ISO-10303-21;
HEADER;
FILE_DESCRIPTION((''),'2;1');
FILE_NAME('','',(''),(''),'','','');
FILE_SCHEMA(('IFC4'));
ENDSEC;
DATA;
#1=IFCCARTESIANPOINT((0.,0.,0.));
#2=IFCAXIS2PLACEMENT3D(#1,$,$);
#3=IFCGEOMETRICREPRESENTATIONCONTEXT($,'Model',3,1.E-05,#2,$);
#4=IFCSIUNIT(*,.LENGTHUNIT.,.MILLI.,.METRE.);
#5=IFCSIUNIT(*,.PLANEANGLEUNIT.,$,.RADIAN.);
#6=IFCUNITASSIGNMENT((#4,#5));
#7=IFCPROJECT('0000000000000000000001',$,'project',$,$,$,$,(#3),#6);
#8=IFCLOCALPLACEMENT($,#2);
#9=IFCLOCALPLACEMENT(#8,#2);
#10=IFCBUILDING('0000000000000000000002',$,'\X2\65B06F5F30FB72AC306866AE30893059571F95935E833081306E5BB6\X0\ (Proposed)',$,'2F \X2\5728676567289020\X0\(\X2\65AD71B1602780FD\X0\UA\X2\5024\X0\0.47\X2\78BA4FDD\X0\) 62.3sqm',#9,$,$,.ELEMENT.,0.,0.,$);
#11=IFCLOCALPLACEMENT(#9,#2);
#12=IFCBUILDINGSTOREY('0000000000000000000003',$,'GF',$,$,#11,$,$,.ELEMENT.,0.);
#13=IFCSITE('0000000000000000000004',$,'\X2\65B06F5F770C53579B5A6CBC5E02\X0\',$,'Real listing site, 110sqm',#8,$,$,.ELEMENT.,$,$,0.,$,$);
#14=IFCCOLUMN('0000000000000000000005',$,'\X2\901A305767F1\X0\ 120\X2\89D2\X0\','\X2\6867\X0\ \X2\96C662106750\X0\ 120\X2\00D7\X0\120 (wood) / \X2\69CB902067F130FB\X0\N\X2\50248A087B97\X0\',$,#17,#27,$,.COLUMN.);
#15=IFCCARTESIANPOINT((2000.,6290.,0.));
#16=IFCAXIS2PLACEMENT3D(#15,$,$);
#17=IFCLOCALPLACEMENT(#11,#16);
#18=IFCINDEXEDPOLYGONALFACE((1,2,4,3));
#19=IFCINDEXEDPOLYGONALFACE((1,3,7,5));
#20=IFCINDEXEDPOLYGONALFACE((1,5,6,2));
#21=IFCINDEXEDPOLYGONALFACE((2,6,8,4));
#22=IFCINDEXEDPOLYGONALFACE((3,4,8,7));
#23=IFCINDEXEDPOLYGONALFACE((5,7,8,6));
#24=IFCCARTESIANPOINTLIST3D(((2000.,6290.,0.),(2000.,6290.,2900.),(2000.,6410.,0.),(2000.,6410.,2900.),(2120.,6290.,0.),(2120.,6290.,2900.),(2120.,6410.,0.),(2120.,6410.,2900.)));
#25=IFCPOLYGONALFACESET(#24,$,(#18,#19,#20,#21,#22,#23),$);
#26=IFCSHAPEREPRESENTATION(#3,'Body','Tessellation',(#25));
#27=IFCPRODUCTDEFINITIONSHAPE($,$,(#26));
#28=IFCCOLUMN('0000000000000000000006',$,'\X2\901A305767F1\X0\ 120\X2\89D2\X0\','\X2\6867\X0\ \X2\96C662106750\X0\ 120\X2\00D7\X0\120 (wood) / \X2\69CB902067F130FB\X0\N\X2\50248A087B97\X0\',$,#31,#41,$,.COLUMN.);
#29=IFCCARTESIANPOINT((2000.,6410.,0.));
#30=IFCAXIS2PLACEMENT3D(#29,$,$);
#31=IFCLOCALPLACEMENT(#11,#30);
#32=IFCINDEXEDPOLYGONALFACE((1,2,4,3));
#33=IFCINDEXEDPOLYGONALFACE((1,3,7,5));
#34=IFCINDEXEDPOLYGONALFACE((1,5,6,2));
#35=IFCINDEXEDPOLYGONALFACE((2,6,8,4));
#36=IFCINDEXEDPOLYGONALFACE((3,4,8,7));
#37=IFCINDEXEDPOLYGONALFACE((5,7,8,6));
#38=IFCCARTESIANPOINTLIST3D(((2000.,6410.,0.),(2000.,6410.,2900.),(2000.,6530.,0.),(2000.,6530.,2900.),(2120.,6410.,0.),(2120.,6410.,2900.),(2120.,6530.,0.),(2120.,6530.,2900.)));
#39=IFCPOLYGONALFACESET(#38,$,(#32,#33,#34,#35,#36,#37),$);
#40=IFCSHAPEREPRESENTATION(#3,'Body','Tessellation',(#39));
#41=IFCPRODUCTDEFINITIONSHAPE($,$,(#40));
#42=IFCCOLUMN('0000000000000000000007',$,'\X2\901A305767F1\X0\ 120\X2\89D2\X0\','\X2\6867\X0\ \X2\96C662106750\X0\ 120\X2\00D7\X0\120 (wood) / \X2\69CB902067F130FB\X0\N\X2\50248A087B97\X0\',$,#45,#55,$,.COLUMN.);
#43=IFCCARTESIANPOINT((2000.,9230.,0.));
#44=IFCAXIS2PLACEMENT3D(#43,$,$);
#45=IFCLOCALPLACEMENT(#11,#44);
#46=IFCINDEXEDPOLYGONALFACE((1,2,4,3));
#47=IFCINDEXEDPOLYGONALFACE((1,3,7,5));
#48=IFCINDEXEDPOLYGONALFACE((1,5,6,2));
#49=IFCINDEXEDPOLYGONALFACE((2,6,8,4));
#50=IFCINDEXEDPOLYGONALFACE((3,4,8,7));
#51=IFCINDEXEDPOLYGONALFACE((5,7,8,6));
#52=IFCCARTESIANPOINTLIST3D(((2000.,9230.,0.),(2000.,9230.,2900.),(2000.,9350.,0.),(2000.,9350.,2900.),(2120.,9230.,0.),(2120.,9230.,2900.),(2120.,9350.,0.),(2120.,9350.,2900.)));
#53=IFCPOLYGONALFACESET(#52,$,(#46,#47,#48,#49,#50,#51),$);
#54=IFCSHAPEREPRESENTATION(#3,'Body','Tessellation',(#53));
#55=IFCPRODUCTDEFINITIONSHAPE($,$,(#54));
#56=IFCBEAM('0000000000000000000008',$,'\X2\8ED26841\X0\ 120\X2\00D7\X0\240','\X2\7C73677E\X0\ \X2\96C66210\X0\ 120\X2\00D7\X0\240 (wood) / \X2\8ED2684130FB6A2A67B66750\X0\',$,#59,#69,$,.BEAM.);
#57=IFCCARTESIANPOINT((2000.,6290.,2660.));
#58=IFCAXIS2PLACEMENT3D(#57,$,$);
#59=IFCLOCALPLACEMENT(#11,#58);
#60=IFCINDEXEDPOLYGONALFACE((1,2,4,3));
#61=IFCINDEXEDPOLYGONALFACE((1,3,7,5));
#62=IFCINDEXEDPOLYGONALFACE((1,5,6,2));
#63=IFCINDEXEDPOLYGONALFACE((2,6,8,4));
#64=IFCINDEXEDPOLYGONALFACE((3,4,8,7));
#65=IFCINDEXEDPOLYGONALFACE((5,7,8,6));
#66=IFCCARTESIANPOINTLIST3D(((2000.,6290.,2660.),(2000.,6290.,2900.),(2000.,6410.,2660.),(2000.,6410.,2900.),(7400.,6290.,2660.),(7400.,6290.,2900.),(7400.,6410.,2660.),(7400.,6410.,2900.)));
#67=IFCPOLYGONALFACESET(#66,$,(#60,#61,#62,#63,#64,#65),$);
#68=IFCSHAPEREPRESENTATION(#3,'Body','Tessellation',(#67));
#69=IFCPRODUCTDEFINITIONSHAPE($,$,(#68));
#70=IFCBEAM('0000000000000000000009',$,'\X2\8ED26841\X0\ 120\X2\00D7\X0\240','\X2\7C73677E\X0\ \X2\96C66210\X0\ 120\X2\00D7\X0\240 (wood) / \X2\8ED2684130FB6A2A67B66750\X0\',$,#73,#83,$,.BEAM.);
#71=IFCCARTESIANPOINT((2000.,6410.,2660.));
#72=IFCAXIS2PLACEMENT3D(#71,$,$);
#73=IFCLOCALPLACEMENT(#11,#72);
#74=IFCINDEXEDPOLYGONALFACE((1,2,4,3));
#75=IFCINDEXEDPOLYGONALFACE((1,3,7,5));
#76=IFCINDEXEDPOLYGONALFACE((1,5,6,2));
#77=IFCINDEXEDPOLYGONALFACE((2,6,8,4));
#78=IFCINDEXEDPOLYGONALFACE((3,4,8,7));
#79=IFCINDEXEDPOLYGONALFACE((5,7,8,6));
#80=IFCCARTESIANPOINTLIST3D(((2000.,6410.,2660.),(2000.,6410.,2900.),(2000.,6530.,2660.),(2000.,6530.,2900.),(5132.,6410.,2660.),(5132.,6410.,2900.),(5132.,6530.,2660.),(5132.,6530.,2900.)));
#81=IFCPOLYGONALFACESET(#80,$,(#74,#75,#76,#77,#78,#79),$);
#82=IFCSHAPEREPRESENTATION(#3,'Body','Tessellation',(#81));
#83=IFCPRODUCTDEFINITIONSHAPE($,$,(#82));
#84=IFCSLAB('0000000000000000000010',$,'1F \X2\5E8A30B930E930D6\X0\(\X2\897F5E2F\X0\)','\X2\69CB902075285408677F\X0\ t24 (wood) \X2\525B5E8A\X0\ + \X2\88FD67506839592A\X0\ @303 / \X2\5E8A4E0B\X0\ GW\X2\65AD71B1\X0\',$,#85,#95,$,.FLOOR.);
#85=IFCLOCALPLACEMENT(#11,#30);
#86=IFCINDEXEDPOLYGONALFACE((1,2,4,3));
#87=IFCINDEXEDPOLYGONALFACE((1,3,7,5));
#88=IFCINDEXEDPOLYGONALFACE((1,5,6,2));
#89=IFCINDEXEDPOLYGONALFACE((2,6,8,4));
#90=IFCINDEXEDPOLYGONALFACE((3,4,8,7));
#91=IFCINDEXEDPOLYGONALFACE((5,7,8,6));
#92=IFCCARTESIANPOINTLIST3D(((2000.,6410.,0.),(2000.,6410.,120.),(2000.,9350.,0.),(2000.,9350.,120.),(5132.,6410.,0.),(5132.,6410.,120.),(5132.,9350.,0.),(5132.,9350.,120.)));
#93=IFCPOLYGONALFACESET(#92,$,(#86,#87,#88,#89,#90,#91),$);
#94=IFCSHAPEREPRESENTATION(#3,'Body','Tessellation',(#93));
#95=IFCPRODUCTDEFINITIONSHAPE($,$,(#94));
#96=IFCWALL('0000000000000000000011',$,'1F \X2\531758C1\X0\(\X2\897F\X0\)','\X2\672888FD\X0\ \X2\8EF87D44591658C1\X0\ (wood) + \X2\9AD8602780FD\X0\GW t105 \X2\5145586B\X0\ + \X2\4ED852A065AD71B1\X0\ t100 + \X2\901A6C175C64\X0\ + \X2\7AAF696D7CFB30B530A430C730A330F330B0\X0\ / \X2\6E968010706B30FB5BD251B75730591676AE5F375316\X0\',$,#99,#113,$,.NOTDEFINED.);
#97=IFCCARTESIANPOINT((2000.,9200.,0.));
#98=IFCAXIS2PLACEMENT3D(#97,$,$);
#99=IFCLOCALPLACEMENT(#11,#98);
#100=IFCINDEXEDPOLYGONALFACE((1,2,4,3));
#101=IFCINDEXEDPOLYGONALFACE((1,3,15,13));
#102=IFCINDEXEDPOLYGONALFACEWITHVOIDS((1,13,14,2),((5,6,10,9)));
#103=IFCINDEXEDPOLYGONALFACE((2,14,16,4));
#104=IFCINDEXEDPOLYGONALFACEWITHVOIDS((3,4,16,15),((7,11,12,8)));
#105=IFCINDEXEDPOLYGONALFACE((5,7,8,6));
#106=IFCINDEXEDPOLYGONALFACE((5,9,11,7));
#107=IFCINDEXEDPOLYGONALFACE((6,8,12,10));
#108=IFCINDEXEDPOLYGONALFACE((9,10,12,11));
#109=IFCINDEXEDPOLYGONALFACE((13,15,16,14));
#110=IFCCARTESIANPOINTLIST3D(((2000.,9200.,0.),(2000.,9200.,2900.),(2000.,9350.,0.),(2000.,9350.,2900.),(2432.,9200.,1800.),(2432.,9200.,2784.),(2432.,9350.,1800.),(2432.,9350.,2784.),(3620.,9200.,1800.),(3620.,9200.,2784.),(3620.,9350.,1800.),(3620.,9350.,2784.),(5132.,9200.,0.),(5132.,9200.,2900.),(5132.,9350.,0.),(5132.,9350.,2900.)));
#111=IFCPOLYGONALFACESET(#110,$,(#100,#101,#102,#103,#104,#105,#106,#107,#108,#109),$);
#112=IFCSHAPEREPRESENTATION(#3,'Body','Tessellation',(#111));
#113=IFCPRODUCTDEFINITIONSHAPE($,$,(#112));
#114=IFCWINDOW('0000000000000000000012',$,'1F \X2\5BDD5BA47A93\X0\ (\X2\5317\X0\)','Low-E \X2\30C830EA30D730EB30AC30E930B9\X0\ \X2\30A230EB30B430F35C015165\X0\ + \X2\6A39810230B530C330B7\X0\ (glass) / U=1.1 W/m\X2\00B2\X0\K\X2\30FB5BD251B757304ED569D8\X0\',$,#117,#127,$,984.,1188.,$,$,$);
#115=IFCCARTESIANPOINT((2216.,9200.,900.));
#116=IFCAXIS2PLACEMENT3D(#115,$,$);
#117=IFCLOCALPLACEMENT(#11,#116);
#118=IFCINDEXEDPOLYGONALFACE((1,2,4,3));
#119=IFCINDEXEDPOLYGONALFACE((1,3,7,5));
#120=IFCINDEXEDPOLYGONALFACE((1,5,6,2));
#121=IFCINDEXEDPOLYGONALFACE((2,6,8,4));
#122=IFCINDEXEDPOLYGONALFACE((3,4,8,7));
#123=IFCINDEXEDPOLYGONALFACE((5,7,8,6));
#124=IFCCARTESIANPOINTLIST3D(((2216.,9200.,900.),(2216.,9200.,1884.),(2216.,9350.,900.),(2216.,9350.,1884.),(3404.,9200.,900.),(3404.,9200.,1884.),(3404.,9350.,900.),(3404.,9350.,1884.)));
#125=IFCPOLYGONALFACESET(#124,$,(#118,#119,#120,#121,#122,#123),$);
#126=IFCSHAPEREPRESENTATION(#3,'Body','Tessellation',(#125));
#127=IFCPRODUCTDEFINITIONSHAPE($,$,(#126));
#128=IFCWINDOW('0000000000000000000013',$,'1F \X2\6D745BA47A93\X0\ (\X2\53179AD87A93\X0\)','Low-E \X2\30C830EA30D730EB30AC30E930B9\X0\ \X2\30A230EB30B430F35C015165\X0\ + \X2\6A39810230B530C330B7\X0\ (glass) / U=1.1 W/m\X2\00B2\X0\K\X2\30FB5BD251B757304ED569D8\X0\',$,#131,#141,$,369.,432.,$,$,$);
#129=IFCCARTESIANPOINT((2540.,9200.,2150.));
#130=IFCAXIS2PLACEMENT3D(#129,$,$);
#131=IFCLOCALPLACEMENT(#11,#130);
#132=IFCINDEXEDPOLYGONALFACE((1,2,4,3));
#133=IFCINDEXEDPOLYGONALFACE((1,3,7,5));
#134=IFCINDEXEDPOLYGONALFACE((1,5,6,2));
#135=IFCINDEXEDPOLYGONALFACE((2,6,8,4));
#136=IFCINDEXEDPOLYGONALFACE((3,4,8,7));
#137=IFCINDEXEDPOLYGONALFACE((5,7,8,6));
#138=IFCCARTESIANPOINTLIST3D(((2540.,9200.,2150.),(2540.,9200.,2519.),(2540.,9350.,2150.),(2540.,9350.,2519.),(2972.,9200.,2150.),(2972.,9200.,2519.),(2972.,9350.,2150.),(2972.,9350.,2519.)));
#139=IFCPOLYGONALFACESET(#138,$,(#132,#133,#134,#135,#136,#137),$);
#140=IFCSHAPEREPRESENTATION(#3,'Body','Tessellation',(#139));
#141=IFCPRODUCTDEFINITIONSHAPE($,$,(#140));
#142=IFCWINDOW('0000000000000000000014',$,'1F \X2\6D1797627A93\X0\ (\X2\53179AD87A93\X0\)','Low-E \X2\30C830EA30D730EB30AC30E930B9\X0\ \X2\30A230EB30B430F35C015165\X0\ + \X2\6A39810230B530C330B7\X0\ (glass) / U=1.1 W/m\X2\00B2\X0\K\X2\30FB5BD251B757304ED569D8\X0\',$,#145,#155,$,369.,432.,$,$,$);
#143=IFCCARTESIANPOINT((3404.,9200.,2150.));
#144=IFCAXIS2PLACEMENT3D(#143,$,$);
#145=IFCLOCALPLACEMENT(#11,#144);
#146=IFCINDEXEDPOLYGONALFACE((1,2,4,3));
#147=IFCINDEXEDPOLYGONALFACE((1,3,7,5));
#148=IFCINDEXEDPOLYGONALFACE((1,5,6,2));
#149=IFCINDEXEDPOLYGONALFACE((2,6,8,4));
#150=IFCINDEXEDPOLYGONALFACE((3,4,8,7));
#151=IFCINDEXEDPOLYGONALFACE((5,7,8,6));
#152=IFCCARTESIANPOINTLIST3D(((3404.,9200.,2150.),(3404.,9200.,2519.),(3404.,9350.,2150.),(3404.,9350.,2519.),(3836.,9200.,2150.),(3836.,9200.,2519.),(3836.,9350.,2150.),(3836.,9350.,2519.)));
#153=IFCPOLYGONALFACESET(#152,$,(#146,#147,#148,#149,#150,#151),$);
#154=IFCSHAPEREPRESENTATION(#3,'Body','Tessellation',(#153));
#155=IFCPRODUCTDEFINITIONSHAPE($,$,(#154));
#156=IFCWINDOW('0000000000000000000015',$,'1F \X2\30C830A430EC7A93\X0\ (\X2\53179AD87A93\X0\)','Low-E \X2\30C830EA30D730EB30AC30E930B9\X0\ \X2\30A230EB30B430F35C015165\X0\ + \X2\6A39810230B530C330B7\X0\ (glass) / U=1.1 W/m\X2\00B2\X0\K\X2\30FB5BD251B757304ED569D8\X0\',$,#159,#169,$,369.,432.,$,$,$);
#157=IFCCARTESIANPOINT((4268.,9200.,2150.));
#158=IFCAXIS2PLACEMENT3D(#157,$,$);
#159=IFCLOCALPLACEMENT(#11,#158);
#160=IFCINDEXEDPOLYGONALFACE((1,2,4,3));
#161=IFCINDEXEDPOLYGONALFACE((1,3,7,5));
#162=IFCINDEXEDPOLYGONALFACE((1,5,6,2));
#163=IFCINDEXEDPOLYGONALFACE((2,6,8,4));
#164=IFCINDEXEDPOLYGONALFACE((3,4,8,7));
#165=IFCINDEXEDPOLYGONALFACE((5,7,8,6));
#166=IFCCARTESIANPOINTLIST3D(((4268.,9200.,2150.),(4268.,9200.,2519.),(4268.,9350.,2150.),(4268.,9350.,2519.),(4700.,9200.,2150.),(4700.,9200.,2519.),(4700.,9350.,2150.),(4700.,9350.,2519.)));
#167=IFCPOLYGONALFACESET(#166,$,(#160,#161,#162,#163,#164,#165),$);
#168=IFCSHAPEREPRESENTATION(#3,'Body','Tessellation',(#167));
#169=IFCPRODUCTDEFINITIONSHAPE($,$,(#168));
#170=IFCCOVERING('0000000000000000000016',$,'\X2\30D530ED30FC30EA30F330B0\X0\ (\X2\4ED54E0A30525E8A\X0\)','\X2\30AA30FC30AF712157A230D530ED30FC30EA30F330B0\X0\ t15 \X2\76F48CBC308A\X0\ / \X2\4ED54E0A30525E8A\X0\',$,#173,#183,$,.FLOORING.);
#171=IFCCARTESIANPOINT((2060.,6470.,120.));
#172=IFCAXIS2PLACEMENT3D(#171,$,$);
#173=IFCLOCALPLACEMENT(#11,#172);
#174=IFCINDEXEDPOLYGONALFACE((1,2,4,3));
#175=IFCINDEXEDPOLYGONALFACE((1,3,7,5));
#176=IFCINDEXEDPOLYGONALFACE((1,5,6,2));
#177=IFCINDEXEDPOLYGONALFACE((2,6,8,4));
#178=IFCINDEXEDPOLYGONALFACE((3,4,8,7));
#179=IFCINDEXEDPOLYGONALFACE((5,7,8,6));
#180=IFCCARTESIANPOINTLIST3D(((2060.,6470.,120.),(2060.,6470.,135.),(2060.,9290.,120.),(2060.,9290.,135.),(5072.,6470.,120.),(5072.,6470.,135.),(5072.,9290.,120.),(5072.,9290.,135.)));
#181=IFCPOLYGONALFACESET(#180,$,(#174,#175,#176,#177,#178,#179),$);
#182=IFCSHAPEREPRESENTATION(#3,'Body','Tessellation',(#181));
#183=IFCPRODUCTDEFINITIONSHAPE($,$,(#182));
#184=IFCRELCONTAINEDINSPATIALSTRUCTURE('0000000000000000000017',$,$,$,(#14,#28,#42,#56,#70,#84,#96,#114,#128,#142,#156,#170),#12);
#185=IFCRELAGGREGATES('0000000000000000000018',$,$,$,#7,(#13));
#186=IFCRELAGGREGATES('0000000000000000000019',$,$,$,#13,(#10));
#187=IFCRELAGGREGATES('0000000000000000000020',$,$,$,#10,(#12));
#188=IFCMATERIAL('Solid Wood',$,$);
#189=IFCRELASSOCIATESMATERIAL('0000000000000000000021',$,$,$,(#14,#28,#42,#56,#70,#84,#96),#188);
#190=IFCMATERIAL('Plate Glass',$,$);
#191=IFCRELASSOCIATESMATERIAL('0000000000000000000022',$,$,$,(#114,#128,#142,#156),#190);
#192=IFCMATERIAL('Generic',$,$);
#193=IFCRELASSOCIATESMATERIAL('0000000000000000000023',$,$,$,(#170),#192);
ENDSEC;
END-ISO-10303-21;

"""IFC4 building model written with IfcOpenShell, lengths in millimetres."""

from ifc_helpers import new_model, si_unit, frame, frame_2d, origin, place, context, project, spatial, rectangle, extrude, material, element, fill, save


model = new_model("IFC4")

# Units and contexts
model_context = context("Model", 3, precision=1e-05, world=origin())
ifc_project = project(units=[si_unit("LENGTHUNIT", "METRE", prefix="MILLI"), si_unit("PLANEANGLEUNIT", "RADIAN")], contexts=[model_context])

# Site, building, storey
site_placement = place(None, origin())
site = spatial("IfcSite", under=ifc_project, at=site_placement, Name="新潟県南魚沼市", ObjectType="Real listing site, 110sqm", CompositionType="ELEMENT", RefElevation=0.0)
building_placement = place(site_placement, origin())
building = spatial("IfcBuilding", under=site, at=building_placement, Name="新潟・犬と暮らす土間広めの家 (Proposed)", ObjectType="2F 在来木造(断熱性能UA値0.47確保) 62.3sqm", CompositionType="ELEMENT", ElevationOfRefHeight=0.0, ElevationOfTerrain=0.0)
storey_placement = place(building_placement, origin())
storey = spatial("IfcBuildingStorey", under=building, at=storey_placement, Name="GF", CompositionType="ELEMENT", Elevation=0.0)

# Columns
ifc_material_1 = material(Name="Solid Wood")
column_1_placement = place(storey_placement, frame((2000.0, 6290.0, 0.0)))
element("IfcColumn", 1, at=column_1_placement, inside=storey, material=ifc_material_1, Name="通し柱 120角", Description="桧 集成材 120×120 (wood) / 構造柱・N値計算", PredefinedType="COLUMN", context=model_context, shape_type="SweptSolid", body=[
    extrude(rectangle(XDim=120.0, YDim=120.0, at=frame_2d((60.0, 60.0))), frame((2000.0, 6290.0, 0.0)), (0.0, 0.0, 1.0), 2900.0),
])
column_2_placement = place(storey_placement, frame((2000.0, 6410.0, 0.0)))
element("IfcColumn", 2, at=column_2_placement, inside=storey, material=ifc_material_1, Name="通し柱 120角", Description="桧 集成材 120×120 (wood) / 構造柱・N値計算", PredefinedType="COLUMN", context=model_context, shape_type="SweptSolid", body=[
    extrude(rectangle(XDim=120.0, YDim=120.0, at=frame_2d((60.0, 60.0))), frame((2000.0, 6410.0, 0.0)), (0.0, 0.0, 1.0), 2900.0),
])
column_3_placement = place(storey_placement, frame((2000.0, 9230.0, 0.0)))
element("IfcColumn", 3, at=column_3_placement, inside=storey, material=ifc_material_1, Name="通し柱 120角", Description="桧 集成材 120×120 (wood) / 構造柱・N値計算", PredefinedType="COLUMN", context=model_context, shape_type="SweptSolid", body=[
    extrude(rectangle(XDim=120.0, YDim=120.0, at=frame_2d((60.0, 60.0))), frame((2000.0, 9230.0, 0.0)), (0.0, 0.0, 1.0), 2900.0),
])

# Beams
beam_1_placement = place(storey_placement, frame((2000.0, 6290.0, 2660.0)))
element("IfcBeam", 4, at=beam_1_placement, inside=storey, material=ifc_material_1, Name="軒桁 120×240", Description="米松 集成 120×240 (wood) / 軒桁・横架材", PredefinedType="BEAM", context=model_context, shape_type="SweptSolid", body=[
    extrude(rectangle(XDim=5400.0, YDim=120.0, at=frame_2d((2700.0, 60.0))), frame((2000.0, 6290.0, 2660.0)), (0.0, 0.0, 1.0), 240.0),
])
beam_2_placement = place(storey_placement, frame((2000.0, 6410.0, 2660.0)))
element("IfcBeam", 5, at=beam_2_placement, inside=storey, material=ifc_material_1, Name="軒桁 120×240", Description="米松 集成 120×240 (wood) / 軒桁・横架材", PredefinedType="BEAM", context=model_context, shape_type="SweptSolid", body=[
    extrude(rectangle(XDim=3132.0, YDim=120.0, at=frame_2d((1566.0, 60.0))), frame((2000.0, 6410.0, 2660.0)), (0.0, 0.0, 1.0), 240.0),
])

# Slab
slab_placement = place(storey_placement, frame((2000.0, 6410.0, 0.0)))
element("IfcSlab", 6, at=slab_placement, inside=storey, material=ifc_material_1, Name="1F 床スラブ(西帯)", Description="構造用合板 t24 (wood) 剛床 + 製材根太 @303 / 床下 GW断熱", PredefinedType="FLOOR", context=model_context, shape_type="SweptSolid", body=[
    extrude(rectangle(XDim=3132.0, YDim=2940.0, at=frame_2d((1566.0, 1470.0))), frame((2000.0, 6410.0, 0.0)), (0.0, 0.0, 1.0), 120.0),
])

# Wall, openings, windows
wall_1_placement = place(storey_placement, frame((2000.0, 9200.0, 0.0)))
wall_1 = element("IfcWall", 7, at=wall_1_placement, inside=storey, material=ifc_material_1, Name="1F 北壁(西)", Description="木製 軸組外壁 (wood) + 高性能GW t105 充填 + 付加断熱 t100 + 通気層 + 窯業系サイディング / 準耐火・寒冷地外皮強化", PredefinedType="NOTDEFINED", context=model_context, shape_type="SweptSolid", body=[
    extrude(rectangle(XDim=3132.0, YDim=150.0, at=frame_2d((1566.0, 75.0))), frame((2000.0, 9200.0, 0.0)), (0.0, 0.0, 1.0), 2900.0),
])
opening_1_placement = place(storey_placement, frame((2216.0, 9200.0, 900.0)))
opening_1 = element("IfcOpeningElement", 8, at=opening_1_placement, cuts=wall_1, PredefinedType="NOTDEFINED", context=model_context, shape_type="SweptSolid", body=[
    extrude(rectangle(XDim=1188.0, YDim=150.0, at=frame_2d((594.0, 75.0))), frame((2216.0, 9200.0, 900.0)), (0.0, 0.0, 1.0), 984.0),
])
opening_2_placement = place(storey_placement, frame((2540.0, 9200.0, 2150.0)))
opening_2 = element("IfcOpeningElement", 9, at=opening_2_placement, cuts=wall_1, PredefinedType="NOTDEFINED", context=model_context, shape_type="SweptSolid", body=[
    extrude(rectangle(XDim=432.0, YDim=150.0, at=frame_2d((216.0, 75.0))), frame((2540.0, 9200.0, 2150.0)), (0.0, 0.0, 1.0), 369.0),
])
opening_3_placement = place(storey_placement, frame((3404.0, 9200.0, 2150.0)))
opening_3 = element("IfcOpeningElement", 10, at=opening_3_placement, cuts=wall_1, PredefinedType="NOTDEFINED", context=model_context, shape_type="SweptSolid", body=[
    extrude(rectangle(XDim=432.0, YDim=150.0, at=frame_2d((216.0, 75.0))), frame((3404.0, 9200.0, 2150.0)), (0.0, 0.0, 1.0), 369.0),
])
opening_4_placement = place(storey_placement, frame((4268.0, 9200.0, 2150.0)))
opening_4 = element("IfcOpeningElement", 11, at=opening_4_placement, cuts=wall_1, PredefinedType="NOTDEFINED", context=model_context, shape_type="SweptSolid", body=[
    extrude(rectangle(XDim=432.0, YDim=150.0, at=frame_2d((216.0, 75.0))), frame((4268.0, 9200.0, 2150.0)), (0.0, 0.0, 1.0), 369.0),
])
ifc_material_2 = material(Name="Plate Glass")
window_1_placement = place(storey_placement, frame((2216.0, 9200.0, 900.0)))
window_1 = element("IfcWindow", 12, at=window_1_placement, inside=storey, material=ifc_material_2, Name="1F 寝室窓 (北)", Description="Low-E トリプルガラス アルゴン封入 + 樹脂サッシ (glass) / U=1.1 W/m²K・寒冷地仕様", OverallHeight=984.0, OverallWidth=1188.0, context=model_context, shape_type="SweptSolid", body=[
    extrude(rectangle(XDim=1188.0, YDim=150.0, at=frame_2d((594.0, 75.0))), frame((2216.0, 9200.0, 900.0)), (0.0, 0.0, 1.0), 984.0),
])
fill(opening_1, window_1)
window_2_placement = place(storey_placement, frame((2540.0, 9200.0, 2150.0)))
window_2 = element("IfcWindow", 13, at=window_2_placement, inside=storey, material=ifc_material_2, Name="1F 浴室窓 (北高窓)", Description="Low-E トリプルガラス アルゴン封入 + 樹脂サッシ (glass) / U=1.1 W/m²K・寒冷地仕様", OverallHeight=369.0, OverallWidth=432.0, context=model_context, shape_type="SweptSolid", body=[
    extrude(rectangle(XDim=432.0, YDim=150.0, at=frame_2d((216.0, 75.0))), frame((2540.0, 9200.0, 2150.0)), (0.0, 0.0, 1.0), 369.0),
])
fill(opening_2, window_2)
window_3_placement = place(storey_placement, frame((3404.0, 9200.0, 2150.0)))
window_3 = element("IfcWindow", 14, at=window_3_placement, inside=storey, material=ifc_material_2, Name="1F 洗面窓 (北高窓)", Description="Low-E トリプルガラス アルゴン封入 + 樹脂サッシ (glass) / U=1.1 W/m²K・寒冷地仕様", OverallHeight=369.0, OverallWidth=432.0, context=model_context, shape_type="SweptSolid", body=[
    extrude(rectangle(XDim=432.0, YDim=150.0, at=frame_2d((216.0, 75.0))), frame((3404.0, 9200.0, 2150.0)), (0.0, 0.0, 1.0), 369.0),
])
fill(opening_3, window_3)
window_4_placement = place(storey_placement, frame((4268.0, 9200.0, 2150.0)))
window_4 = element("IfcWindow", 15, at=window_4_placement, inside=storey, material=ifc_material_2, Name="1F トイレ窓 (北高窓)", Description="Low-E トリプルガラス アルゴン封入 + 樹脂サッシ (glass) / U=1.1 W/m²K・寒冷地仕様", OverallHeight=369.0, OverallWidth=432.0, context=model_context, shape_type="SweptSolid", body=[
    extrude(rectangle(XDim=432.0, YDim=150.0, at=frame_2d((216.0, 75.0))), frame((4268.0, 9200.0, 2150.0)), (0.0, 0.0, 1.0), 369.0),
])
fill(opening_4, window_4)

# Covering
ifc_material_3 = material(Name="Generic")
covering_placement = place(storey_placement, frame((2060.0, 6470.0, 120.0)))
element("IfcCovering", 16, at=covering_placement, inside=storey, material=ifc_material_3, Name="フローリング (仕上げ床)", Description="オーク無垢フローリング t15 直貼り / 仕上げ床", PredefinedType="FLOORING", context=model_context, shape_type="SweptSolid", body=[
    extrude(rectangle(XDim=3012.0, YDim=2820.0, at=frame_2d((1506.0, 1410.0))), frame((2060.0, 6470.0, 120.0)), (0.0, 0.0, 1.0), 15.0),
])

save(model, "model.ifc")
